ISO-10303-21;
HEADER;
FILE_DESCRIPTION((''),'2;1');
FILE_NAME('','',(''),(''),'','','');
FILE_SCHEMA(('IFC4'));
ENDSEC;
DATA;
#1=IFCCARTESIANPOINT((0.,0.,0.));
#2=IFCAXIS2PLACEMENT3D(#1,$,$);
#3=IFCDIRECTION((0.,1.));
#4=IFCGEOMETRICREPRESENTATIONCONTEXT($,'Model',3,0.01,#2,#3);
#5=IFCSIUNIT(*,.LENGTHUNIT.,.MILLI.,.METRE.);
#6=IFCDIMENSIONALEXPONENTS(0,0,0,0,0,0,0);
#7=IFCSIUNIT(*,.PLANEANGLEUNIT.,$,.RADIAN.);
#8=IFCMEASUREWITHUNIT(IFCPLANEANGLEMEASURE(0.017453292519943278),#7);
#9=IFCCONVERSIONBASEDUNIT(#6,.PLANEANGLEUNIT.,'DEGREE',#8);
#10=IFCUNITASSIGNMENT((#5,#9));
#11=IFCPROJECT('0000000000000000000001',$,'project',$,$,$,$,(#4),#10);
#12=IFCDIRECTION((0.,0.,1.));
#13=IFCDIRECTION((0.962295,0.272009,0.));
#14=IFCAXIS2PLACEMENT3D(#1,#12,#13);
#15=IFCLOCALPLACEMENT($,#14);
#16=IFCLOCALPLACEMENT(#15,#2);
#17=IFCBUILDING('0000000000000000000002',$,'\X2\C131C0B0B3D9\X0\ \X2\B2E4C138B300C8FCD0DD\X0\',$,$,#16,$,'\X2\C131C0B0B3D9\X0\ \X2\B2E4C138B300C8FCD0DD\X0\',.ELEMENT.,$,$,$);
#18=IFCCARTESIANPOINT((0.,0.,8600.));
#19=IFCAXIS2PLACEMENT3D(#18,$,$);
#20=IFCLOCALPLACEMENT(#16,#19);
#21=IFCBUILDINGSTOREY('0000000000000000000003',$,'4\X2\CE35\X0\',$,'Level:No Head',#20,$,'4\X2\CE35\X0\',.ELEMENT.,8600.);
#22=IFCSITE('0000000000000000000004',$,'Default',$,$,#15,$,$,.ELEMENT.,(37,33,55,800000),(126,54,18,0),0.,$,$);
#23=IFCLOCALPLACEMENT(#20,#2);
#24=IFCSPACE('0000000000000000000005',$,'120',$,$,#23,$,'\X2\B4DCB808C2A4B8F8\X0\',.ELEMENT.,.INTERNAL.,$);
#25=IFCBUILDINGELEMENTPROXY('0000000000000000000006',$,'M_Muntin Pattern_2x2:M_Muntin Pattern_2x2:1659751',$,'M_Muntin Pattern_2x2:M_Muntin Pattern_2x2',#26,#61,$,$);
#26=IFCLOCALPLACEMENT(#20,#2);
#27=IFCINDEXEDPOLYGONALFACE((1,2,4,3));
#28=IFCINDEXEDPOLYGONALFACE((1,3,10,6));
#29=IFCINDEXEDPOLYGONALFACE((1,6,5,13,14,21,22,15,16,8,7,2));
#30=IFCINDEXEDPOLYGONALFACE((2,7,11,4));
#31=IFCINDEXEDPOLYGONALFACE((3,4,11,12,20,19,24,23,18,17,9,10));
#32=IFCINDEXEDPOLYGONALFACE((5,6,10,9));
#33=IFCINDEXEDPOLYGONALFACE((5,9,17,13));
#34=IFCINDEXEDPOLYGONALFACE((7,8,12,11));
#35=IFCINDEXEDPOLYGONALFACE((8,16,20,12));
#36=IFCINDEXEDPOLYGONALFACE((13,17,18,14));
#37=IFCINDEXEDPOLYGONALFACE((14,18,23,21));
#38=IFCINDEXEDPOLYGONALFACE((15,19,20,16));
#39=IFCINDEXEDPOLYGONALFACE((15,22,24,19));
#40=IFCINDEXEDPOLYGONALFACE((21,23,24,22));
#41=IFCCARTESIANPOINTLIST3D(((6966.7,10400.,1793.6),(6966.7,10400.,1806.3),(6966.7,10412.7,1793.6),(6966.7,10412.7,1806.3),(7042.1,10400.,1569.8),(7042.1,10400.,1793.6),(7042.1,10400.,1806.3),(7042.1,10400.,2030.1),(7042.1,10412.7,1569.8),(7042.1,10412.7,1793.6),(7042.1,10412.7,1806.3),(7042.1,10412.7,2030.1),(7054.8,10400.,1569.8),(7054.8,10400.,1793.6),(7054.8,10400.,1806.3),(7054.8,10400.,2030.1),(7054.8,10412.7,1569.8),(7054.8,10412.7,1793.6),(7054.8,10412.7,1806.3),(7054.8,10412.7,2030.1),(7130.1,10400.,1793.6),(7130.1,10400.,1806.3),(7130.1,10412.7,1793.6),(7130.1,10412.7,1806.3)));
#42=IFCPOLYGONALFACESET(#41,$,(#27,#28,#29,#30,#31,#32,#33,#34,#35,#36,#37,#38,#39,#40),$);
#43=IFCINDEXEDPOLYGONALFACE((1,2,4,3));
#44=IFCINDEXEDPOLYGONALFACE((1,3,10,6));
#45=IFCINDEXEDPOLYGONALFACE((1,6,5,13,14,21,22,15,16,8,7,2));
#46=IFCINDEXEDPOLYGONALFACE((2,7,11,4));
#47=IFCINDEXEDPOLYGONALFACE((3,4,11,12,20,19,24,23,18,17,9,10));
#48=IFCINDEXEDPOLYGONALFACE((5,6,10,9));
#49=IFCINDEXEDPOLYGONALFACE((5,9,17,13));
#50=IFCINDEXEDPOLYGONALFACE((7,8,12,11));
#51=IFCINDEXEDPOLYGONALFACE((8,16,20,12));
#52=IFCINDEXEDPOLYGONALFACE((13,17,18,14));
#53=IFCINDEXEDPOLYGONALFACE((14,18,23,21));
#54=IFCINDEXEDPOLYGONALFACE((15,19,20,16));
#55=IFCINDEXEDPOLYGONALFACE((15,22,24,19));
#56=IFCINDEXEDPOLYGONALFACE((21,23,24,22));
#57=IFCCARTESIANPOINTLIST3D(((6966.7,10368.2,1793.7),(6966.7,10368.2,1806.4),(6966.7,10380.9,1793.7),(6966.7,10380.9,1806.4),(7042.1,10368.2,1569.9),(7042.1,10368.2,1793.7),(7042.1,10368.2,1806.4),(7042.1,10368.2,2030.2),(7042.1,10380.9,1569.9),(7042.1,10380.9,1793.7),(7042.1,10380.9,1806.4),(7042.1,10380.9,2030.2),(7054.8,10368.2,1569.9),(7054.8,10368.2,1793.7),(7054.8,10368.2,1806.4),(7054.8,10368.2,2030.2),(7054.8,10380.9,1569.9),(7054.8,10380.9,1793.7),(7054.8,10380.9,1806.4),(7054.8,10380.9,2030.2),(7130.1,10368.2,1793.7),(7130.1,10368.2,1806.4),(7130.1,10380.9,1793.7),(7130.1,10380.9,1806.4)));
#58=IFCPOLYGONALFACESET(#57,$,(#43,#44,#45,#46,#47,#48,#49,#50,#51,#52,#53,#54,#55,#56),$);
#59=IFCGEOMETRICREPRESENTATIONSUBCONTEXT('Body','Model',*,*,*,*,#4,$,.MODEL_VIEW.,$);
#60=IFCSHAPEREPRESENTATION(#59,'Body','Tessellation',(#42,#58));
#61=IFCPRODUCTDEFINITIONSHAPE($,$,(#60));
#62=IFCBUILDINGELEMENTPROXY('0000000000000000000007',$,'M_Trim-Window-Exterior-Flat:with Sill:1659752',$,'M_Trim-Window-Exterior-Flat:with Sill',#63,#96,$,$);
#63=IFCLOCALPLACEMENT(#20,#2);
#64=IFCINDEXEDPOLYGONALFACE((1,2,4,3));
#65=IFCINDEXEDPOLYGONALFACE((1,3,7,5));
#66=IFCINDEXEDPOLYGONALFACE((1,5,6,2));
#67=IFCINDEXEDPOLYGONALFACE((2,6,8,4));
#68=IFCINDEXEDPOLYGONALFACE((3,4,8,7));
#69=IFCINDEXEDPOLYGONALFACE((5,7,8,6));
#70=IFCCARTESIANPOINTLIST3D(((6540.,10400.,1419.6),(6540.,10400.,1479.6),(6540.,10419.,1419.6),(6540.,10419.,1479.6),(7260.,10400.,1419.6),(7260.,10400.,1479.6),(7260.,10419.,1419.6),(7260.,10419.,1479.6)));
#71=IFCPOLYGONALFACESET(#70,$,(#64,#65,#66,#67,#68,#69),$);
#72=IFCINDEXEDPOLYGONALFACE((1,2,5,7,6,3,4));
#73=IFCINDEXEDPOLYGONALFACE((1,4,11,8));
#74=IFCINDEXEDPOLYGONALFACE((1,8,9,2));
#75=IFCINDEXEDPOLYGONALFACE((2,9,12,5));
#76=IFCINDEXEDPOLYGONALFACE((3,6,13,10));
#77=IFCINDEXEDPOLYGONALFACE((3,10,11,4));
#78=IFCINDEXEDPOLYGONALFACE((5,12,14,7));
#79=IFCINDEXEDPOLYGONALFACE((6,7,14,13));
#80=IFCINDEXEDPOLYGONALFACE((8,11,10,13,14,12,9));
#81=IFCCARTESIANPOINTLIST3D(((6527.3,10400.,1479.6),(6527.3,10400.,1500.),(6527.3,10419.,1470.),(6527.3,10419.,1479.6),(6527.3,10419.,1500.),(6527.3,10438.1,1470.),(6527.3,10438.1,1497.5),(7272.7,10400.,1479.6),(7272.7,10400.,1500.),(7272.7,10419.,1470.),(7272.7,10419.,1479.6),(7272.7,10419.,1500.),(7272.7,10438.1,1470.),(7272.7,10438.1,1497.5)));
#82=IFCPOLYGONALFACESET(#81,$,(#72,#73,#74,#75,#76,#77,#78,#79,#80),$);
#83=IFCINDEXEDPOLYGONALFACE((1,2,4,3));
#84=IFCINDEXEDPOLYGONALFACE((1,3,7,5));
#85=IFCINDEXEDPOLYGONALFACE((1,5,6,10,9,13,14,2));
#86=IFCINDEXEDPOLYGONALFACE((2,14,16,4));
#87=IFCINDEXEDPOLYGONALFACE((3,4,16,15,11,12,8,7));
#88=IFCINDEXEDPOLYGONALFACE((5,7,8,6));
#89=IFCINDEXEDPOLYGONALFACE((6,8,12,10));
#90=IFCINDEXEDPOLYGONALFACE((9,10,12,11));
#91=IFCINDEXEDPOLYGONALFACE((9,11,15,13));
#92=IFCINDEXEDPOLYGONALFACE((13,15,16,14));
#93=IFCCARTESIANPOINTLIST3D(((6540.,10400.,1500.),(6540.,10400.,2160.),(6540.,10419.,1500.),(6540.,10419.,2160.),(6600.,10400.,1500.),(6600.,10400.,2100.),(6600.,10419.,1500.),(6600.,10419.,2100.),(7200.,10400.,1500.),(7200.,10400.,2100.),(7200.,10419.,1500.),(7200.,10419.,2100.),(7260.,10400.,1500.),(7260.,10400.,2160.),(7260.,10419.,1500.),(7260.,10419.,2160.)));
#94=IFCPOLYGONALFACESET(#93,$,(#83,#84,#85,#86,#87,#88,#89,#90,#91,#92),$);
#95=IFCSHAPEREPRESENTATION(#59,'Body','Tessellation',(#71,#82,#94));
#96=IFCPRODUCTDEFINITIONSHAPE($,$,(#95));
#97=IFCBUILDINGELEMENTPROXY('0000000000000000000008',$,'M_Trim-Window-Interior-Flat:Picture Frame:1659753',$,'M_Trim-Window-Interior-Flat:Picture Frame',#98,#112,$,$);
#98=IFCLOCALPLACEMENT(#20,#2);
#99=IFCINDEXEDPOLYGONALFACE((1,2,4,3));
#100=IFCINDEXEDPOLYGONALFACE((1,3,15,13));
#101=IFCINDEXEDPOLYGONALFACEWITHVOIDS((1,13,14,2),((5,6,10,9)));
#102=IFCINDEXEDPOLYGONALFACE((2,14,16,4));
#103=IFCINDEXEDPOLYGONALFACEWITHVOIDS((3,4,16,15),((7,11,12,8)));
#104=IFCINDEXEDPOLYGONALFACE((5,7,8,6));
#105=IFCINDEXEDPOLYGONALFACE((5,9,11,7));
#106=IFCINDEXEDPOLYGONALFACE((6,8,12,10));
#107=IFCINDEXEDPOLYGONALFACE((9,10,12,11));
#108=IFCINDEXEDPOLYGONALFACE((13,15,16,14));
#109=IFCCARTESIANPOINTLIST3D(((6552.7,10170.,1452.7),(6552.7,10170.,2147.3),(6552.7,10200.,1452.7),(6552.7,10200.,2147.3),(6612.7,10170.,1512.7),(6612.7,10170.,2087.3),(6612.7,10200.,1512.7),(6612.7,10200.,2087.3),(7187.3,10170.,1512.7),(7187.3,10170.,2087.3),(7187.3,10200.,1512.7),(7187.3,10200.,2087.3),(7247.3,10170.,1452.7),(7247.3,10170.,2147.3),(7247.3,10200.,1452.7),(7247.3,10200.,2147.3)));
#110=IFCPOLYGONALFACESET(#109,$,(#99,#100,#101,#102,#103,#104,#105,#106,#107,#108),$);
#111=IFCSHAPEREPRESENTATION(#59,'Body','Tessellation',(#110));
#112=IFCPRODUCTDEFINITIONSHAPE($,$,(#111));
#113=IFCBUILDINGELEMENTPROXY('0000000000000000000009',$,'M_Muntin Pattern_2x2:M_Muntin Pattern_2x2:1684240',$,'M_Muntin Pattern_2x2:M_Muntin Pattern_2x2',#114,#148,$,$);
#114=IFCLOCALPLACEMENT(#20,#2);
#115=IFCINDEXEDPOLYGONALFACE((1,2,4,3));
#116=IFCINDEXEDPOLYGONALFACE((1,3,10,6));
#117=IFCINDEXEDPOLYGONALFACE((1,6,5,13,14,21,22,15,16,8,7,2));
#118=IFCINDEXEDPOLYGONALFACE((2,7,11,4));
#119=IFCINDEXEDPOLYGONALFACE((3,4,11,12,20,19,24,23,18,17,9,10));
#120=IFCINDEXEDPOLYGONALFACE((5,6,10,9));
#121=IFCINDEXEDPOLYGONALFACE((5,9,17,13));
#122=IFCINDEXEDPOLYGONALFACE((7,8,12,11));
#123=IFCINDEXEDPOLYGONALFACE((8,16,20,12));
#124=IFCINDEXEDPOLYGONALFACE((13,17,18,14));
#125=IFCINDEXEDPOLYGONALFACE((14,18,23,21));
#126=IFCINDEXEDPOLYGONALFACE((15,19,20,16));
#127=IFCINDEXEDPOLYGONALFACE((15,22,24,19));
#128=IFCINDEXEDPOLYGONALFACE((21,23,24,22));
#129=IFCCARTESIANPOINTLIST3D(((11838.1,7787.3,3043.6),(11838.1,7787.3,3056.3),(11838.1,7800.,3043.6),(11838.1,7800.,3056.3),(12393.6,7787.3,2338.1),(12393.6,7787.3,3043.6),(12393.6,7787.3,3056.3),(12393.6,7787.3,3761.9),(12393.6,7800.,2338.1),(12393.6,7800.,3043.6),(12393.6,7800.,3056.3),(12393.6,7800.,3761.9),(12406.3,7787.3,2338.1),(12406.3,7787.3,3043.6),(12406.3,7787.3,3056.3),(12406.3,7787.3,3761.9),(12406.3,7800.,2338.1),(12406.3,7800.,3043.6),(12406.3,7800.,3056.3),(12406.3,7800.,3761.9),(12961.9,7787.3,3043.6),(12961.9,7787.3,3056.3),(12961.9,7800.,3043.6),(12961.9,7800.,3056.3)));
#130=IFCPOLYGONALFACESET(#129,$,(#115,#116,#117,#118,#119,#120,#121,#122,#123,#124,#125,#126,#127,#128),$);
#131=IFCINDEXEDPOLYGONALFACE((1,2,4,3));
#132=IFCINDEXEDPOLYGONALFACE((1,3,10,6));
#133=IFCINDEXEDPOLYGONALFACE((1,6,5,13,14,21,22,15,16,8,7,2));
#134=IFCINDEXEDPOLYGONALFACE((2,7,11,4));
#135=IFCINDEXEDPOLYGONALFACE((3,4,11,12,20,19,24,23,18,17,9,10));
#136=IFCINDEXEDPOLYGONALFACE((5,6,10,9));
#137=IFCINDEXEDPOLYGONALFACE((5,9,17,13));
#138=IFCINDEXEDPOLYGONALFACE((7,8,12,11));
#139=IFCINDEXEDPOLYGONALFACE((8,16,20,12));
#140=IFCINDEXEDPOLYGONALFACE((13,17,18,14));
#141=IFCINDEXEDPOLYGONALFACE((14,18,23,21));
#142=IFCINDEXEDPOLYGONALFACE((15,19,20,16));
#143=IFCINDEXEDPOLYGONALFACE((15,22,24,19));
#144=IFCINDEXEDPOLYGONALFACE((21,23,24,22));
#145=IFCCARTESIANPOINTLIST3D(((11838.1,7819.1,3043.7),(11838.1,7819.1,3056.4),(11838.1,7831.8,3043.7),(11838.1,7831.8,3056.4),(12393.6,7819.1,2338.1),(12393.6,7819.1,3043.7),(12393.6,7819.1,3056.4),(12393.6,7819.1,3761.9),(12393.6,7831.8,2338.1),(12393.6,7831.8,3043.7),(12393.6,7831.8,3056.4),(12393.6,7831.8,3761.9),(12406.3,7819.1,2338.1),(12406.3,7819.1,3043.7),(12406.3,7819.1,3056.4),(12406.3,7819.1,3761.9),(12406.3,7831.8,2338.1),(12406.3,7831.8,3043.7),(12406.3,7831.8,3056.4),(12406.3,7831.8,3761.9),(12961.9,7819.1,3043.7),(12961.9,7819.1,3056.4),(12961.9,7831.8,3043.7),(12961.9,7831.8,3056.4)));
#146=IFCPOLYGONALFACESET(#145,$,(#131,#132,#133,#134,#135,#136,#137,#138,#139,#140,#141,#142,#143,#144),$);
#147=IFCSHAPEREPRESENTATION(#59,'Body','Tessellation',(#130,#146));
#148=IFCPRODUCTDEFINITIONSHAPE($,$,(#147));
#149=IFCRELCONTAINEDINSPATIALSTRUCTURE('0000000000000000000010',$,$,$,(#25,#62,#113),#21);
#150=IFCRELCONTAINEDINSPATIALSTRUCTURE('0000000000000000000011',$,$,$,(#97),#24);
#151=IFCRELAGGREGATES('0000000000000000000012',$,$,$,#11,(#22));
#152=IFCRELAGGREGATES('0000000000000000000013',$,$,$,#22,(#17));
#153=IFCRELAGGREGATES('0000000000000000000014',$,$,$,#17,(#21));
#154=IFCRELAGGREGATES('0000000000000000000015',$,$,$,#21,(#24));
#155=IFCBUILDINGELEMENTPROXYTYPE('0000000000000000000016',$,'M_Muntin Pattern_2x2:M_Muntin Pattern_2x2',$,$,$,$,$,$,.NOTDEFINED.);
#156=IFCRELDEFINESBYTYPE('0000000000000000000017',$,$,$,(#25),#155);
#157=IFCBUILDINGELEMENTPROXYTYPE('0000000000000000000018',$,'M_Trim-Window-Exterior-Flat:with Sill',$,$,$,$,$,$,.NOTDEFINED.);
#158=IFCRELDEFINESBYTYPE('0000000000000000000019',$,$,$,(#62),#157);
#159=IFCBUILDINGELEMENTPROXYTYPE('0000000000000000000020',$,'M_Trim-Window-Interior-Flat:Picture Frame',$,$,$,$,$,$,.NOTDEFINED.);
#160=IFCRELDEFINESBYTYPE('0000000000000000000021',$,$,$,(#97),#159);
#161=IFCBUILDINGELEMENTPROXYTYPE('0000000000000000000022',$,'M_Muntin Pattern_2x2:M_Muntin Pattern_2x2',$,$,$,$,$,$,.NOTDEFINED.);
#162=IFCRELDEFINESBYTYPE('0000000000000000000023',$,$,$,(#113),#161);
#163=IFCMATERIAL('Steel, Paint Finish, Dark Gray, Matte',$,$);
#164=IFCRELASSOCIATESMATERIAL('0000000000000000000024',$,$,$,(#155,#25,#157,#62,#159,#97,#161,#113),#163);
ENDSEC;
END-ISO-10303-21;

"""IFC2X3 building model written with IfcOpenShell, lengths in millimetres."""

from ifc_helpers import new_model, entity, si_unit, converted_unit, direction, frame, frame_2d, origin, place, context, subcontext, project, spatial, polyline, rectangle, outline, extrude, source, transform, mapped, material, type_object, type_shapes, element, save


model = new_model("IFC2X3")

# Units and contexts
model_context = context("Model", 3, precision=0.01, world=origin(), true_north=direction((0.0, 1.0)))
body_context = subcontext(model_context, "Body", "Model", "MODEL_VIEW")
ifc_project = project(units=[si_unit("LENGTHUNIT", "METRE", prefix="MILLI"), converted_unit("PLANEANGLEUNIT", "DEGREE", entity("IfcPlaneAngleMeasure", 0.017453292519943278), si_unit("PLANEANGLEUNIT", "RADIAN"), dimensions=[0, 0, 0, 0, 0, 0, 0])], contexts=[model_context])

# Site, building, storey
site_placement = place(None, frame((0.0, 0.0, 0.0), z_axis=(0.0, 0.0, 1.0), x_axis=(0.962295, 0.272009, 0.0)))
site = spatial("IfcSite", under=ifc_project, at=site_placement, Name="Default", CompositionType="ELEMENT", RefLatitude=(37, 33, 55, 800000), RefLongitude=(126, 54, 18, 0), RefElevation=0.0)
building_placement = place(site_placement, origin())
building = spatial("IfcBuilding", under=site, at=building_placement, Name="성산동 다세대주택", LongName="성산동 다세대주택", CompositionType="ELEMENT")
storey_placement = place(building_placement, frame((0.0, 0.0, 8600.0)))
storey = spatial("IfcBuildingStorey", under=building, at=storey_placement, Name="4층", ObjectType="Level:No Head", LongName="4층", CompositionType="ELEMENT", Elevation=8600.0)

# Shared definitions
space_1_placement = place(storey_placement, origin())
space_1 = spatial("IfcSpace", under=storey, at=space_1_placement, Name="120", LongName="드레스룸", CompositionType="ELEMENT", InteriorOrExteriorSpace="INTERNAL")

# Building element proxies
ifc_material_1 = material(Name="Steel, Paint Finish, Dark Gray, Matte")
building_element_proxy_type_1 = type_object("IfcBuildingElementProxyType", Name="M_Muntin Pattern_2x2:M_Muntin Pattern_2x2", PredefinedType="NOTDEFINED", material=ifc_material_1)
shared_shape_1 = source(origin(), body_context, "Body", "SweptSolid", [
    extrude(outline(polyline([(6.4, -6.4), (230.1, -6.4), (230.1, 6.3), (6.4, 6.3), (6.4, 81.7), (-6.3, 81.7), (-6.3, 6.3), (-230.2, 6.3), (-230.2, -6.4), (-6.3, -6.4), (-6.3, -81.7), (6.4, -81.7), (6.4, -6.4)])), frame((0.0, -22.2, 230.1), z_axis=(0.0, 1.0, 0.0), x_axis=(0.0, 0.0, 1.0)), (0.0, 0.0, 1.0), 12.7),
    extrude(outline(polyline([(6.4, -6.4), (230.2, -6.4), (230.2, 6.3), (6.4, 6.3), (6.4, 81.7), (-6.3, 81.7), (-6.3, 6.3), (-230.2, 6.3), (-230.2, -6.4), (-6.3, -6.4), (-6.3, -81.7), (6.4, -81.7), (6.4, -6.4)])), frame((0.0, 9.5, 230.2), z_axis=(0.0, 1.0, 0.0), x_axis=(0.0, 0.0, 1.0)), (0.0, 0.0, 1.0), 12.7),
])
type_shapes(building_element_proxy_type_1, [shared_shape_1])
proxy_1_placement = place(storey_placement, frame((7048.4, 10390.5, 1569.9), z_axis=(0.0, 0.0, 1.0), x_axis=(-1.0, 0.0, 0.0)))
element("IfcBuildingElementProxy", 1, at=proxy_1_placement, inside=storey, type_object=building_element_proxy_type_1, material=ifc_material_1, Name="M_Muntin Pattern_2x2:M_Muntin Pattern_2x2:1659751", ObjectType="M_Muntin Pattern_2x2:M_Muntin Pattern_2x2", context=body_context, shape_type="MappedRepresentation", body=[
    mapped(shared_shape_1, transform((0.0, 0.0, 0.0), scale=1.0)),
])
building_element_proxy_type_2 = type_object("IfcBuildingElementProxyType", Name="M_Trim-Window-Exterior-Flat:with Sill", PredefinedType="NOTDEFINED", material=ifc_material_1)
shared_shape_2 = source(origin(), body_context, "Body", "SweptSolid", [
    extrude(rectangle(XDim=720.0, YDim=60.0, at=frame_2d((0.0, 0.0), x_axis=(1.0, 0.0))), frame((0.0, -650.4, 0.0), z_axis=(0.0, 0.0, 1.0), x_axis=(-1.0, 0.0, 0.0)), (0.0, 0.0, 1.0), 19.0),
    extrude(outline(polyline([(-19.0, -15.2), (0.0, -15.2), (0.0, -5.7), (19.0, -5.7), (19.0, 14.8), (0.0, 14.8), (-19.0, 12.3), (-19.0, -15.2)])), frame((-372.7, -614.8, 19.0), z_axis=(1.0, 0.0, 0.0), x_axis=(0.0, 0.0, -1.0)), (0.0, 0.0, 1.0), 745.4),
    extrude(outline(polyline([(-345.0, -360.0), (315.0, -360.0), (315.0, -300.0), (-285.0, -300.0), (-285.0, 300.0), (315.0, 300.0), (315.0, 360.0), (-345.0, 360.0), (-345.0, -360.0)])), frame((0.0, -285.0, 0.0), z_axis=(0.0, 0.0, 1.0), x_axis=(0.0, -1.0, 0.0)), (0.0, 0.0, 1.0), 19.0),
])
type_shapes(building_element_proxy_type_2, [shared_shape_2])
proxy_2_placement = place(storey_placement, frame((6900.0, 10400.0, 2100.0), z_axis=(0.0, 1.0, 0.0), x_axis=(-1.0, 0.0, 0.0)))
element("IfcBuildingElementProxy", 2, at=proxy_2_placement, inside=storey, type_object=building_element_proxy_type_2, material=ifc_material_1, Name="M_Trim-Window-Exterior-Flat:with Sill:1659752", ObjectType="M_Trim-Window-Exterior-Flat:with Sill", context=body_context, shape_type="MappedRepresentation", body=[
    mapped(shared_shape_2, transform((0.0, 0.0, 0.0), scale=1.0)),
])
building_element_proxy_type_3 = type_object("IfcBuildingElementProxyType", Name="M_Trim-Window-Interior-Flat:Picture Frame", PredefinedType="NOTDEFINED", material=ifc_material_1)
shared_shape_3 = source(origin(), body_context, "Body", "SweptSolid", [
    extrude(outline(polyline([(-347.3, -347.3), (347.3, -347.3), (347.3, 347.3), (-347.3, 347.3), (-347.3, -347.3)]), holes=[polyline([(-287.3, -287.3), (-287.3, 287.3), (287.3, 287.3), (287.3, -287.3), (-287.3, -287.3)])]), frame((0.0, -300.0, 0.0), z_axis=(0.0, 0.0, 1.0), x_axis=(-1.0, 0.0, 0.0)), (0.0, 0.0, 1.0), 30.0),
])
type_shapes(building_element_proxy_type_3, [shared_shape_3])
proxy_3_placement = place(space_1_placement, frame((6900.0, 10200.0, 2100.0), z_axis=(0.0, -1.0, 0.0), x_axis=(1.0, 0.0, 0.0)))
element("IfcBuildingElementProxy", 3, at=proxy_3_placement, inside=space_1, type_object=building_element_proxy_type_3, material=ifc_material_1, Name="M_Trim-Window-Interior-Flat:Picture Frame:1659753", ObjectType="M_Trim-Window-Interior-Flat:Picture Frame", context=body_context, shape_type="MappedRepresentation", body=[
    mapped(shared_shape_3, transform((0.0, 0.0, 0.0), scale=1.0)),
])
building_element_proxy_type_4 = type_object("IfcBuildingElementProxyType", Name="M_Muntin Pattern_2x2:M_Muntin Pattern_2x2", PredefinedType="NOTDEFINED", material=ifc_material_1)
shared_shape_4 = source(origin(), body_context, "Body", "SweptSolid", [
    extrude(outline(polyline([(6.4, -6.4), (711.9, -6.4), (711.9, 6.3), (6.4, 6.3), (6.4, 561.9), (-6.3, 561.9), (-6.3, 6.3), (-711.9, 6.3), (-711.9, -6.4), (-6.3, -6.4), (-6.3, -561.9), (6.4, -561.9), (6.4, -6.4)])), frame((0.0, -22.2, 711.9), z_axis=(0.0, 1.0, 0.0), x_axis=(0.0, 0.0, 1.0)), (0.0, 0.0, 1.0), 12.7),
    extrude(outline(polyline([(6.4, -6.4), (711.9, -6.4), (711.9, 6.3), (6.4, 6.3), (6.4, 561.9), (-6.3, 561.9), (-6.3, 6.3), (-711.9, 6.3), (-711.9, -6.4), (-6.3, -6.4), (-6.3, -561.9), (6.4, -561.9), (6.4, -6.4)])), frame((0.0, 9.5, 711.9), z_axis=(0.0, 1.0, 0.0), x_axis=(0.0, 0.0, 1.0)), (0.0, 0.0, 1.0), 12.7),
])
type_shapes(building_element_proxy_type_4, [shared_shape_4])
proxy_4_placement = place(storey_placement, frame((12400.0, 7809.5, 2338.1)))
element("IfcBuildingElementProxy", 4, at=proxy_4_placement, inside=storey, type_object=building_element_proxy_type_4, material=ifc_material_1, Name="M_Muntin Pattern_2x2:M_Muntin Pattern_2x2:1684240", ObjectType="M_Muntin Pattern_2x2:M_Muntin Pattern_2x2", context=body_context, shape_type="MappedRepresentation", body=[
    mapped(shared_shape_4, transform((0.0, 0.0, 0.0), scale=1.0)),
])

save(model, "model.ifc")
